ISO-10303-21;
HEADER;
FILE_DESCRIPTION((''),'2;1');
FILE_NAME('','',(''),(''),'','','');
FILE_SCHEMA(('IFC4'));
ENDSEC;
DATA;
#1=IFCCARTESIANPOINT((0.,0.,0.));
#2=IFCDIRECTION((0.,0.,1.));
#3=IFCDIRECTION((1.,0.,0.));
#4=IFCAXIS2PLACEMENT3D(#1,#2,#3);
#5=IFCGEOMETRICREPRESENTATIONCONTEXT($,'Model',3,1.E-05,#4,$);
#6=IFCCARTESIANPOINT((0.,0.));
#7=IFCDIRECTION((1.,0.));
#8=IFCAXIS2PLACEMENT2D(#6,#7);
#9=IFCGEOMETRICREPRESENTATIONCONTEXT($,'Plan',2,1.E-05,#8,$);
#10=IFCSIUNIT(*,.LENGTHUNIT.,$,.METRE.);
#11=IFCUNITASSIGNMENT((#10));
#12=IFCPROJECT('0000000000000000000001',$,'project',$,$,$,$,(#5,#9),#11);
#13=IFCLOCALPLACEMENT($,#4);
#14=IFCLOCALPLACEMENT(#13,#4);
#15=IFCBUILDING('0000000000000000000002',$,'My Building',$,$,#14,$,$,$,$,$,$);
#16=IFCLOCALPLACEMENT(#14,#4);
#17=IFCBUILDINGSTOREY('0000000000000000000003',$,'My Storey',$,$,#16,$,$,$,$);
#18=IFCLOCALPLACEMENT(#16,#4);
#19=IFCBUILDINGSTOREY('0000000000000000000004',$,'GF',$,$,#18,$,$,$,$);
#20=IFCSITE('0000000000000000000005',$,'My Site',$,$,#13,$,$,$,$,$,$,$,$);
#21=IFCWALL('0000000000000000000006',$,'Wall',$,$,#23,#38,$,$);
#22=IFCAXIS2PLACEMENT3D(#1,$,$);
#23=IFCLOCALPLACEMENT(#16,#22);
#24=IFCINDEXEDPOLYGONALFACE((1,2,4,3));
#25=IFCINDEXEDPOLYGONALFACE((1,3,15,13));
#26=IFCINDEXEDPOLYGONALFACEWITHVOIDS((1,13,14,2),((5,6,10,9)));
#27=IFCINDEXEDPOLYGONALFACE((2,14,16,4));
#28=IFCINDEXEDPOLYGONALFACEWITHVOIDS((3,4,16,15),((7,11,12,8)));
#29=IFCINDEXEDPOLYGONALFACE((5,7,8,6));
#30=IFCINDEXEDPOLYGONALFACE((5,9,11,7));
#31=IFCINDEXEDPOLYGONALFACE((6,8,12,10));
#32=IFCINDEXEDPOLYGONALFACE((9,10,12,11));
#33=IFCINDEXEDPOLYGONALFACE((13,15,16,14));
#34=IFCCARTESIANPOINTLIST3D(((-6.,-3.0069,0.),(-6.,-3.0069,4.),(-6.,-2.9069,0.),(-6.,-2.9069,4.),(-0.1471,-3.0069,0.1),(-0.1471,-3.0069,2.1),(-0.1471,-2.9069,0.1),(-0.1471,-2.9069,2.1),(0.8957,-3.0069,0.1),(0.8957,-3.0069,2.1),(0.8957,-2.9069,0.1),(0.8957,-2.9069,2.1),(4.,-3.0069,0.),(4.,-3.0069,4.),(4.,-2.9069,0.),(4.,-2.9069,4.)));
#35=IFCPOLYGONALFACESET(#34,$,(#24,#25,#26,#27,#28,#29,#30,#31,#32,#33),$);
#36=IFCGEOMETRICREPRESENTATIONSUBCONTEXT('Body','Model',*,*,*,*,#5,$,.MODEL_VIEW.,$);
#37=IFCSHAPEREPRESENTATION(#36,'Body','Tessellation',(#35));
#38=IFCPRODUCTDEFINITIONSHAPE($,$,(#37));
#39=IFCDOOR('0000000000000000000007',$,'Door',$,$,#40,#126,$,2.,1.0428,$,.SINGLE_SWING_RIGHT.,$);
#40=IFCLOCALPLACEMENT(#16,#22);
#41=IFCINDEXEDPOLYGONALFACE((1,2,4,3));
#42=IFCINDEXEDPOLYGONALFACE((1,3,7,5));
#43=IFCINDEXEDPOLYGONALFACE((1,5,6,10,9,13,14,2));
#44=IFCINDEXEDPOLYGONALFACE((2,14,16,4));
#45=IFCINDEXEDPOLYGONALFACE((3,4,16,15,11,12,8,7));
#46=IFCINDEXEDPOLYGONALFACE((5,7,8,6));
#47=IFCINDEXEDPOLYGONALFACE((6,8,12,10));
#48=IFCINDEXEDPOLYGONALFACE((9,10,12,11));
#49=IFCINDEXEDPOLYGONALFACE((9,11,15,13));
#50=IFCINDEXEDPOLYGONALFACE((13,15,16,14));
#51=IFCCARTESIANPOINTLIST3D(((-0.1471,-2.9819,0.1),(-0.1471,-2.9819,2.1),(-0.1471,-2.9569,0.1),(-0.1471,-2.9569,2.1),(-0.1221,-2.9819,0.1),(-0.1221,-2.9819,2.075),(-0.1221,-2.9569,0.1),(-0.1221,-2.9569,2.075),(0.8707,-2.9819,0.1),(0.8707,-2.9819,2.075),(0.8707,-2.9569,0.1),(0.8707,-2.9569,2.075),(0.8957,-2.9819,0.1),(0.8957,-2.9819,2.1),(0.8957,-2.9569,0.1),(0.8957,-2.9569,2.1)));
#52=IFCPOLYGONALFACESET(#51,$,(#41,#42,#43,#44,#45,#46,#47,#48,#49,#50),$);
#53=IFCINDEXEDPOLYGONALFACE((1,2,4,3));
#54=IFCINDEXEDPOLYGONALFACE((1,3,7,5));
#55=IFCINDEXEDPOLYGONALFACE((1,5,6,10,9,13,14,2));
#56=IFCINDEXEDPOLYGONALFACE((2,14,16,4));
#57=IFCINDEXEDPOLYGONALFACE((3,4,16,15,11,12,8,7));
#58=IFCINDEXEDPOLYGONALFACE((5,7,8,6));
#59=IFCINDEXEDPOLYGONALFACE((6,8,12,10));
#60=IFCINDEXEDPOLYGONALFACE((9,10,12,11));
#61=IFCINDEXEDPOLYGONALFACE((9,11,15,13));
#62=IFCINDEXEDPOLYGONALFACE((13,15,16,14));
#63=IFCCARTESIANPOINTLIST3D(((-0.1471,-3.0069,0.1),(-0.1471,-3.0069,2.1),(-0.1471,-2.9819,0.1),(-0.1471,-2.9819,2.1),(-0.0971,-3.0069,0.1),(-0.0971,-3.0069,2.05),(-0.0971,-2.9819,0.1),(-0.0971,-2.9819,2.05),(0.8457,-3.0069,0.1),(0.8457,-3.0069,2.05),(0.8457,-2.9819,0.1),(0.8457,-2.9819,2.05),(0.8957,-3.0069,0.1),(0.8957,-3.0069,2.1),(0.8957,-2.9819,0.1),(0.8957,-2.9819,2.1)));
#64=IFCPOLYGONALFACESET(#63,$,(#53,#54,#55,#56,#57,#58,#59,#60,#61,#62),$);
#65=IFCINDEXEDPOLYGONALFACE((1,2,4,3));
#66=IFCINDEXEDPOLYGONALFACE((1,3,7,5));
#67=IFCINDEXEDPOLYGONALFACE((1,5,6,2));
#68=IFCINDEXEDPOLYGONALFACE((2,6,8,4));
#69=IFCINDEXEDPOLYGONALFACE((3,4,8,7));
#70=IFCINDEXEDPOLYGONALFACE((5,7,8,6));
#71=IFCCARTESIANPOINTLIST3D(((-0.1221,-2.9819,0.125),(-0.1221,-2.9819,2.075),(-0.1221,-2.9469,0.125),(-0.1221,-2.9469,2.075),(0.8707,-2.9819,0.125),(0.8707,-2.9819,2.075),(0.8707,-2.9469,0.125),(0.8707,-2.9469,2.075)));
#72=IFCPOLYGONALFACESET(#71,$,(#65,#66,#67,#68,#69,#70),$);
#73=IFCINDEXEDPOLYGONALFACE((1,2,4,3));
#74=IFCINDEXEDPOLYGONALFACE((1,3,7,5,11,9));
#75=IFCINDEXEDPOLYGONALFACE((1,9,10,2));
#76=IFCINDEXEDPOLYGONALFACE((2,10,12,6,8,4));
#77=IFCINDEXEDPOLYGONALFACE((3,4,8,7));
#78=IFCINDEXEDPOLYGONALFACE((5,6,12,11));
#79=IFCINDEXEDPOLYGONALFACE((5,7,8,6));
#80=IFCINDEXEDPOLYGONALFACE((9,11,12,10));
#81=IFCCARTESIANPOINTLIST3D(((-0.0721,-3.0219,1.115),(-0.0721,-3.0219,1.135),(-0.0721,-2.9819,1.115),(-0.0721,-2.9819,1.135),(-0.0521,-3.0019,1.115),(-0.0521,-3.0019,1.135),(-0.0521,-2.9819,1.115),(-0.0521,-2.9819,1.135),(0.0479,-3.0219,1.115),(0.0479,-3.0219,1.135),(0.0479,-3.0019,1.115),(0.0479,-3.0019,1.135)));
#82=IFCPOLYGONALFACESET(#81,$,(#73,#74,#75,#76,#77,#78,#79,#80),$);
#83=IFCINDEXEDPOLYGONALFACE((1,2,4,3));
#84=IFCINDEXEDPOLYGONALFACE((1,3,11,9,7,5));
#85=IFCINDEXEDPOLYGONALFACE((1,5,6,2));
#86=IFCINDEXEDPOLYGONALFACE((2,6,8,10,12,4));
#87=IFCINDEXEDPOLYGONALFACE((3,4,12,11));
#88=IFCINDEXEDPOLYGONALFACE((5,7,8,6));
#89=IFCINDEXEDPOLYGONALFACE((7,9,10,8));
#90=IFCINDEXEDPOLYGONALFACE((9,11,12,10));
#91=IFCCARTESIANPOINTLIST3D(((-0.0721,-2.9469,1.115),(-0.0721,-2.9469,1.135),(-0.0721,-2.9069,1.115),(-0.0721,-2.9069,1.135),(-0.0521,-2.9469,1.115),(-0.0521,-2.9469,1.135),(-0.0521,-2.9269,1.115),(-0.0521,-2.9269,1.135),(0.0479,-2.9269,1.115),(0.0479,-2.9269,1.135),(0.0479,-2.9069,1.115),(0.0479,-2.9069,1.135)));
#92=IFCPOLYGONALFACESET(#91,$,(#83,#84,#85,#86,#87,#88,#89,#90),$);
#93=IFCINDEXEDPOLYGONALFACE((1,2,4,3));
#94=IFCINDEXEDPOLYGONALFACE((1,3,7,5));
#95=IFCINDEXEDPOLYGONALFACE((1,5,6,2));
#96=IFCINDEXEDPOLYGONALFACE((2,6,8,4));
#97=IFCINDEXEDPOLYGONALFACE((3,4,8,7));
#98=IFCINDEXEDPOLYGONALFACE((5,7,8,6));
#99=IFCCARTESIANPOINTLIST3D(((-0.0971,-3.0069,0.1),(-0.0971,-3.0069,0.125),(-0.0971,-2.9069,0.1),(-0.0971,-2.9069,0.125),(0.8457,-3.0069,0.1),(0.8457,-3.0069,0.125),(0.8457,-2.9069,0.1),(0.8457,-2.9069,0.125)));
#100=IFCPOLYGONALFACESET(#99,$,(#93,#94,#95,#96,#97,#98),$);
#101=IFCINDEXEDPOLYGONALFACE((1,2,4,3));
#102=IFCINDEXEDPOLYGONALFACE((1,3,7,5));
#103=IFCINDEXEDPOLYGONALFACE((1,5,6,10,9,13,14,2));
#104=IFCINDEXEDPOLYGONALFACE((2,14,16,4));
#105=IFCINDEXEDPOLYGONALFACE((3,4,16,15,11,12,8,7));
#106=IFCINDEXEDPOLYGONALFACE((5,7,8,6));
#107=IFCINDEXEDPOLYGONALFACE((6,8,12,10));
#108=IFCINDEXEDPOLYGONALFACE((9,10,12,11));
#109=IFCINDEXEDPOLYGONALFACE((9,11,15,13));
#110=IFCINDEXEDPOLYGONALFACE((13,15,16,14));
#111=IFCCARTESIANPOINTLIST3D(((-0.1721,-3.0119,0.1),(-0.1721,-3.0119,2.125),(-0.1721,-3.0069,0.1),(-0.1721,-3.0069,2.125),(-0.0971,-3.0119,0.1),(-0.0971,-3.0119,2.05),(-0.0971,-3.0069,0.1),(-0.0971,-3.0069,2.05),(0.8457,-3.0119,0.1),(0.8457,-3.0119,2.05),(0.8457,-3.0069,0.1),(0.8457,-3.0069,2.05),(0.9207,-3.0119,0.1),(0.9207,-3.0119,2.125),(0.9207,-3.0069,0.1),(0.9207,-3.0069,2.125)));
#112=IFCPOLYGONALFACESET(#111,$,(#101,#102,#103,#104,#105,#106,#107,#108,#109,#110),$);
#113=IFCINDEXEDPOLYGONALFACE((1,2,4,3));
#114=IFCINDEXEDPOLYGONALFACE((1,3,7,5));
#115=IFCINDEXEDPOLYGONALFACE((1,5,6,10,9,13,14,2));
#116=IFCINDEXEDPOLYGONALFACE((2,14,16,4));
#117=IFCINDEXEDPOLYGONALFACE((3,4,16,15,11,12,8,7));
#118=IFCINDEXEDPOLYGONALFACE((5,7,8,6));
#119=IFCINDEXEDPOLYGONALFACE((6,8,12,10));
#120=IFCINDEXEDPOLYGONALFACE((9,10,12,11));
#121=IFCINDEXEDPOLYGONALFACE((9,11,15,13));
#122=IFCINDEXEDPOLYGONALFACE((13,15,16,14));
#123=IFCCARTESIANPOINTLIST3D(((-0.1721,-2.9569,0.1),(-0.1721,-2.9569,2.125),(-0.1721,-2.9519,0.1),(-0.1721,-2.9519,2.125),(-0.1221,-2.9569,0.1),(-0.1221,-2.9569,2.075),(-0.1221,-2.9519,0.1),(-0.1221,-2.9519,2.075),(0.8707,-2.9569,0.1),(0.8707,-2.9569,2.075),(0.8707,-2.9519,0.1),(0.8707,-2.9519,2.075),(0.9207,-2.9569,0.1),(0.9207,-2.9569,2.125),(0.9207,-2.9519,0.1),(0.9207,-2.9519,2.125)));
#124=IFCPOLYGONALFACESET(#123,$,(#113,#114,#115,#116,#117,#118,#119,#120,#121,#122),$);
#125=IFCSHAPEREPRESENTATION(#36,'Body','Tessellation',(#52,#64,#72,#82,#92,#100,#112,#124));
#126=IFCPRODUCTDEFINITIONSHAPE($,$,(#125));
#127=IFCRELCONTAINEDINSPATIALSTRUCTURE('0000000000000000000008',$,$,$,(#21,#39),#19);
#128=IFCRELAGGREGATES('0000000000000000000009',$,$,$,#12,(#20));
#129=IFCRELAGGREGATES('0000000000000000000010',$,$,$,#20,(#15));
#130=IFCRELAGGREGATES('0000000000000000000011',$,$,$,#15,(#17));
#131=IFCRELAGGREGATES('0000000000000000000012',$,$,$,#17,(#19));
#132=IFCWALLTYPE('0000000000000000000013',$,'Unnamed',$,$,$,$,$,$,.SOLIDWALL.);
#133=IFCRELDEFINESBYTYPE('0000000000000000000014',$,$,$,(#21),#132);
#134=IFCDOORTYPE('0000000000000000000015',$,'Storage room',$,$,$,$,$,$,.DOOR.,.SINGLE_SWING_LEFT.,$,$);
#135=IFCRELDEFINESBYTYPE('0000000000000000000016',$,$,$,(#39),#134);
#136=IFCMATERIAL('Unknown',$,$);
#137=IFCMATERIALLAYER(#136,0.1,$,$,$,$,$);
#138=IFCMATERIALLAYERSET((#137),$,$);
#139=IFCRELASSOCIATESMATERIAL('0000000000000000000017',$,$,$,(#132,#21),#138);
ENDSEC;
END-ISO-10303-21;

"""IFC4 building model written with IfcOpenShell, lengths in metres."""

from ifc_helpers import new_model, entity, si_unit, frame, origin_with_axes, origin_2d_with_axis, place, context, subcontext, project, spatial, line, indexed_curve, outline, extrude, shape, source, transform, mapped, material, layer, layer_set, layer_usage, type_object, type_shapes, element, fill, save


model = new_model("IFC4")

# Units and contexts
model_context = context("Model", 3, precision=1e-05, world=origin_with_axes())
plan_context = context("Plan", 2, precision=1e-05, world=origin_2d_with_axis())
body_context_1 = subcontext(model_context, "Body", "Model", "MODEL_VIEW")
body_context_2 = subcontext(plan_context, "Body", "Plan", "PLAN_VIEW")
ifc_project = project(units=[si_unit("LENGTHUNIT", "METRE")], contexts=[model_context, plan_context])

# Site, building, storeys
site_placement = place(None, origin_with_axes())
site = spatial("IfcSite", under=ifc_project, at=site_placement, Name="My Site")
building_placement = place(site_placement, origin_with_axes())
building = spatial("IfcBuilding", under=site, at=building_placement, Name="My Building")
storey_1_placement = place(building_placement, origin_with_axes())
storey_1 = spatial("IfcBuildingStorey", under=building, at=storey_1_placement, Name="My Storey")
storey_2_placement = place(storey_1_placement, origin_with_axes())
storey_2 = spatial("IfcBuildingStorey", under=storey_1, at=storey_2_placement, Name="GF")

# Shared definitions
ifc_material = material(Name="Unknown")

# Shared definitions
ifc_layer_1 = layer(ifc_material, 0.1)
ifc_layer_set_1 = layer_set([ifc_layer_1])
wall_type = type_object("IfcWallType", Name="Unnamed", PredefinedType="SOLIDWALL", material=ifc_layer_set_1)

# Wall, opening, door
ifc_layer_usage_1 = layer_usage(ifc_layer_set_1, "AXIS2", "POSITIVE", 0.0)
wall_1_placement = place(storey_2_placement, frame((4.0, -2.9069, 0.0), z_axis=(0.0, 0.0, 1.0), x_axis=(-1.0, 0.0, 0.0)))
wall_1 = element("IfcWall", 1, at=wall_1_placement, inside=storey_2, type_object=wall_type, material=ifc_layer_usage_1, Name="Wall", context=body_context_1, shape_type="SweptSolid", body=[
    extrude(outline(indexed_curve([(0.0, 0.0), (0.0, 0.1), (10.0, 0.1), (10.0, 0.0)], segments=[line(1, 2, 3, 4, 1)])), origin_with_axes(), (0.0, 0.0, 1.0), 4.0),
])
shared_shape_1 = source(origin_with_axes(), body_context_1, "Body", "SweptSolid", [
    extrude(outline(indexed_curve([(0.0, 0.0), (1.0428, 0.0), (1.0428, 2.0), (0.0, 2.0)], segments=[line(1, 2, 3, 4, 1)])), frame((0.0, -0.6, 0.0), z_axis=(0.0, -1.0, 0.0), x_axis=(1.0, 0.0, 0.0)), (0.0, 0.0, -1.0), 1.2),
])
opening_1_placement = place(wall_1_placement, frame((4.1471, 0.1, 0.1), z_axis=(0.0, 0.0, 1.0), x_axis=(-1.0, 0.0, 0.0)))
opening_1 = element("IfcOpeningElement", 2, at=opening_1_placement, cuts=wall_1, PredefinedType="OPENING", context=body_context_1, shape_type="MappedRepresentation", body=[
    mapped(shared_shape_1, transform((0.0, 0.0, 0.0), x_axis=(1.0, 0.0, 0.0), y_axis=(0.0, 1.0, 0.0), z_axis=(0.0, 0.0, 1.0), scale=1.0)),
])
door_type_1 = type_object("IfcDoorType", Name="Storage room", OperationType="SINGLE_SWING_LEFT", PredefinedType="DOOR")
shared_shape_2 = source(origin_with_axes(), body_context_1, "Body", "SweptSolid", [
    extrude(outline(indexed_curve([(0.0, 0.0), (0.0, 2.0), (1.0428, 2.0), (1.0428, 0.0), (1.0178, 0.0), (1.0178, 1.975), (0.025, 1.975), (0.025, 0.0)], segments=[line(1, 2, 3, 4, 5, 6, 7, 8, 1)])), frame((0.0, 0.025, 0.0), z_axis=(0.0, -1.0, 0.0), x_axis=(1.0, 0.0, 0.0)), (0.0, 0.0, -1.0), 0.025),
    extrude(outline(indexed_curve([(0.0, 0.0), (0.0, 2.0), (1.0428, 2.0), (1.0428, 0.0), (0.9928, 0.0), (0.9928, 1.95), (0.05, 1.95), (0.05, 0.0)], segments=[line(1, 2, 3, 4, 5, 6, 7, 8, 1)])), frame((0.0, 0.0, 0.0), z_axis=(0.0, -1.0, 0.0), x_axis=(1.0, 0.0, 0.0)), (0.0, 0.0, -1.0), 0.025),
    extrude(outline(indexed_curve([(0.0, 0.0), (0.9928, 0.0), (0.9928, 0.035), (0.0, 0.035)], segments=[line(1, 2, 3, 4, 1)])), frame((0.025, 0.025, 0.025), z_axis=(0.0, 0.0, 1.0), x_axis=(1.0, 0.0, 0.0)), (0.0, 0.0, 1.0), 1.95),
    extrude(outline(indexed_curve([(0.0, 0.0), (0.0, -0.04), (0.12, -0.04), (0.12, -0.02), (0.02, -0.02), (0.02, 0.0)], segments=[line(1, 2, 3, 4, 5, 6, 1)])), frame((0.075, 0.025, 1.015), z_axis=(0.0, 0.0, 1.0), x_axis=(1.0, 0.0, 0.0)), (0.0, 0.0, 1.0), 0.02),
    extrude(outline(indexed_curve([(0.0, 0.0), (0.0, 0.04), (0.12, 0.04), (0.12, 0.02), (0.02, 0.02), (0.02, 0.0)], segments=[line(1, 2, 3, 4, 5, 6, 1)])), frame((0.075, 0.06, 1.015), z_axis=(0.0, 0.0, 1.0), x_axis=(1.0, 0.0, 0.0)), (0.0, 0.0, 1.0), 0.02),
    extrude(outline(indexed_curve([(0.0, 0.0), (0.9428, 0.0), (0.9428, 0.1), (0.0, 0.1)], segments=[line(1, 2, 3, 4, 1)])), frame((0.05, 0.0, 0.0), z_axis=(0.0, 0.0, 1.0), x_axis=(1.0, 0.0, 0.0)), (0.0, 0.0, 1.0), 0.025),
    extrude(outline(indexed_curve([(0.0, 0.0), (0.0, 2.025), (1.0928, 2.025), (1.0928, 0.0), (1.0178, 0.0), (1.0178, 1.95), (0.075, 1.95), (0.075, 0.0)], segments=[line(1, 2, 3, 4, 5, 6, 7, 8, 1)])), frame((-0.025, -0.005, 0.0), z_axis=(0.0, -1.0, 0.0), x_axis=(1.0, 0.0, 0.0)), (0.0, 0.0, -1.0), 0.005),
    extrude(outline(indexed_curve([(0.0, 0.0), (0.0, 2.025), (1.0928, 2.025), (1.0928, 0.0), (1.0428, 0.0), (1.0428, 1.975), (0.05, 1.975), (0.05, 0.0)], segments=[line(1, 2, 3, 4, 5, 6, 7, 8, 1)])), frame((-0.025, 0.05, 0.0), z_axis=(0.0, -1.0, 0.0), x_axis=(1.0, 0.0, 0.0)), (0.0, 0.0, -1.0), 0.005),
])
shared_shape_3 = source(origin_with_axes(), body_context_2, "Body", "Curve2D", [
    entity("IfcIndexedPolyCurve", entity("IfcCartesianPointList2D", [[0.0, 0.0], [0.0, 0.05], [0.025, 0.05], [0.025, 0.025], [0.05, 0.025], [0.05, 0.0]]), [entity("IfcLineIndex", [1, 2, 3, 4, 5, 6, 1])]),
    entity("IfcIndexedPolyCurve", entity("IfcCartesianPointList2D", [[1.0428, 0.0], [1.0428, 0.05], [1.0178, 0.05], [1.0178, 0.025], [0.9928, 0.025], [0.9928, 0.0]]), [entity("IfcLineIndex", [1, 2, 3, 4, 5, 6, 1])]),
    entity("IfcTrimmedCurve", entity("IfcEllipse", entity("IfcAxis2Placement2D", entity("IfcCartesianPoint", [0.9828, 0.05]), entity("IfcDirection", [1.0, 0.0])), 0.9578, 0.9928), [entity("IfcCartesianPoint", [0.9828, 1.0428])], [entity("IfcCartesianPoint", [0.025, 0.05])], True, "CARTESIAN"),
    entity("IfcIndexedPolyCurve", entity("IfcCartesianPointList2D", [[1.0178, 0.05], [0.9828, 0.05], [0.9828, 1.0428], [1.0178, 1.0428]]), [entity("IfcLineIndex", [1, 2, 3, 4, 1])]),
])
type_shapes(door_type_1, [shared_shape_2, shared_shape_3])
door_1_placement = place(opening_1_placement, frame((0.0, 0.0, 0.0), z_axis=(0.0, 0.0, 1.0), x_axis=(1.0, 0.0, 0.0)))
door_1 = element("IfcDoor", 3, at=door_1_placement, inside=storey_2, type_object=door_type_1, Name="Door", OperationType="SINGLE_SWING_RIGHT", OverallHeight=2.0, OverallWidth=1.0428, shapes=[
    shape(body_context_1, "Body", "MappedRepresentation", [mapped(shared_shape_2, transform((0.0, 0.0, 0.0), x_axis=(1.0, 0.0, 0.0), y_axis=(0.0, 1.0, 0.0), z_axis=(0.0, 0.0, 1.0), scale=1.0))]),
    shape(body_context_2, "Body", "MappedRepresentation", [mapped(shared_shape_3, transform((0.0, 0.0, 0.0), x_axis=(1.0, 0.0, 0.0), y_axis=(0.0, 1.0, 0.0), z_axis=(0.0, 0.0, 1.0), scale=1.0))]),
])
fill(opening_1, door_1)

save(model, "model.ifc")
